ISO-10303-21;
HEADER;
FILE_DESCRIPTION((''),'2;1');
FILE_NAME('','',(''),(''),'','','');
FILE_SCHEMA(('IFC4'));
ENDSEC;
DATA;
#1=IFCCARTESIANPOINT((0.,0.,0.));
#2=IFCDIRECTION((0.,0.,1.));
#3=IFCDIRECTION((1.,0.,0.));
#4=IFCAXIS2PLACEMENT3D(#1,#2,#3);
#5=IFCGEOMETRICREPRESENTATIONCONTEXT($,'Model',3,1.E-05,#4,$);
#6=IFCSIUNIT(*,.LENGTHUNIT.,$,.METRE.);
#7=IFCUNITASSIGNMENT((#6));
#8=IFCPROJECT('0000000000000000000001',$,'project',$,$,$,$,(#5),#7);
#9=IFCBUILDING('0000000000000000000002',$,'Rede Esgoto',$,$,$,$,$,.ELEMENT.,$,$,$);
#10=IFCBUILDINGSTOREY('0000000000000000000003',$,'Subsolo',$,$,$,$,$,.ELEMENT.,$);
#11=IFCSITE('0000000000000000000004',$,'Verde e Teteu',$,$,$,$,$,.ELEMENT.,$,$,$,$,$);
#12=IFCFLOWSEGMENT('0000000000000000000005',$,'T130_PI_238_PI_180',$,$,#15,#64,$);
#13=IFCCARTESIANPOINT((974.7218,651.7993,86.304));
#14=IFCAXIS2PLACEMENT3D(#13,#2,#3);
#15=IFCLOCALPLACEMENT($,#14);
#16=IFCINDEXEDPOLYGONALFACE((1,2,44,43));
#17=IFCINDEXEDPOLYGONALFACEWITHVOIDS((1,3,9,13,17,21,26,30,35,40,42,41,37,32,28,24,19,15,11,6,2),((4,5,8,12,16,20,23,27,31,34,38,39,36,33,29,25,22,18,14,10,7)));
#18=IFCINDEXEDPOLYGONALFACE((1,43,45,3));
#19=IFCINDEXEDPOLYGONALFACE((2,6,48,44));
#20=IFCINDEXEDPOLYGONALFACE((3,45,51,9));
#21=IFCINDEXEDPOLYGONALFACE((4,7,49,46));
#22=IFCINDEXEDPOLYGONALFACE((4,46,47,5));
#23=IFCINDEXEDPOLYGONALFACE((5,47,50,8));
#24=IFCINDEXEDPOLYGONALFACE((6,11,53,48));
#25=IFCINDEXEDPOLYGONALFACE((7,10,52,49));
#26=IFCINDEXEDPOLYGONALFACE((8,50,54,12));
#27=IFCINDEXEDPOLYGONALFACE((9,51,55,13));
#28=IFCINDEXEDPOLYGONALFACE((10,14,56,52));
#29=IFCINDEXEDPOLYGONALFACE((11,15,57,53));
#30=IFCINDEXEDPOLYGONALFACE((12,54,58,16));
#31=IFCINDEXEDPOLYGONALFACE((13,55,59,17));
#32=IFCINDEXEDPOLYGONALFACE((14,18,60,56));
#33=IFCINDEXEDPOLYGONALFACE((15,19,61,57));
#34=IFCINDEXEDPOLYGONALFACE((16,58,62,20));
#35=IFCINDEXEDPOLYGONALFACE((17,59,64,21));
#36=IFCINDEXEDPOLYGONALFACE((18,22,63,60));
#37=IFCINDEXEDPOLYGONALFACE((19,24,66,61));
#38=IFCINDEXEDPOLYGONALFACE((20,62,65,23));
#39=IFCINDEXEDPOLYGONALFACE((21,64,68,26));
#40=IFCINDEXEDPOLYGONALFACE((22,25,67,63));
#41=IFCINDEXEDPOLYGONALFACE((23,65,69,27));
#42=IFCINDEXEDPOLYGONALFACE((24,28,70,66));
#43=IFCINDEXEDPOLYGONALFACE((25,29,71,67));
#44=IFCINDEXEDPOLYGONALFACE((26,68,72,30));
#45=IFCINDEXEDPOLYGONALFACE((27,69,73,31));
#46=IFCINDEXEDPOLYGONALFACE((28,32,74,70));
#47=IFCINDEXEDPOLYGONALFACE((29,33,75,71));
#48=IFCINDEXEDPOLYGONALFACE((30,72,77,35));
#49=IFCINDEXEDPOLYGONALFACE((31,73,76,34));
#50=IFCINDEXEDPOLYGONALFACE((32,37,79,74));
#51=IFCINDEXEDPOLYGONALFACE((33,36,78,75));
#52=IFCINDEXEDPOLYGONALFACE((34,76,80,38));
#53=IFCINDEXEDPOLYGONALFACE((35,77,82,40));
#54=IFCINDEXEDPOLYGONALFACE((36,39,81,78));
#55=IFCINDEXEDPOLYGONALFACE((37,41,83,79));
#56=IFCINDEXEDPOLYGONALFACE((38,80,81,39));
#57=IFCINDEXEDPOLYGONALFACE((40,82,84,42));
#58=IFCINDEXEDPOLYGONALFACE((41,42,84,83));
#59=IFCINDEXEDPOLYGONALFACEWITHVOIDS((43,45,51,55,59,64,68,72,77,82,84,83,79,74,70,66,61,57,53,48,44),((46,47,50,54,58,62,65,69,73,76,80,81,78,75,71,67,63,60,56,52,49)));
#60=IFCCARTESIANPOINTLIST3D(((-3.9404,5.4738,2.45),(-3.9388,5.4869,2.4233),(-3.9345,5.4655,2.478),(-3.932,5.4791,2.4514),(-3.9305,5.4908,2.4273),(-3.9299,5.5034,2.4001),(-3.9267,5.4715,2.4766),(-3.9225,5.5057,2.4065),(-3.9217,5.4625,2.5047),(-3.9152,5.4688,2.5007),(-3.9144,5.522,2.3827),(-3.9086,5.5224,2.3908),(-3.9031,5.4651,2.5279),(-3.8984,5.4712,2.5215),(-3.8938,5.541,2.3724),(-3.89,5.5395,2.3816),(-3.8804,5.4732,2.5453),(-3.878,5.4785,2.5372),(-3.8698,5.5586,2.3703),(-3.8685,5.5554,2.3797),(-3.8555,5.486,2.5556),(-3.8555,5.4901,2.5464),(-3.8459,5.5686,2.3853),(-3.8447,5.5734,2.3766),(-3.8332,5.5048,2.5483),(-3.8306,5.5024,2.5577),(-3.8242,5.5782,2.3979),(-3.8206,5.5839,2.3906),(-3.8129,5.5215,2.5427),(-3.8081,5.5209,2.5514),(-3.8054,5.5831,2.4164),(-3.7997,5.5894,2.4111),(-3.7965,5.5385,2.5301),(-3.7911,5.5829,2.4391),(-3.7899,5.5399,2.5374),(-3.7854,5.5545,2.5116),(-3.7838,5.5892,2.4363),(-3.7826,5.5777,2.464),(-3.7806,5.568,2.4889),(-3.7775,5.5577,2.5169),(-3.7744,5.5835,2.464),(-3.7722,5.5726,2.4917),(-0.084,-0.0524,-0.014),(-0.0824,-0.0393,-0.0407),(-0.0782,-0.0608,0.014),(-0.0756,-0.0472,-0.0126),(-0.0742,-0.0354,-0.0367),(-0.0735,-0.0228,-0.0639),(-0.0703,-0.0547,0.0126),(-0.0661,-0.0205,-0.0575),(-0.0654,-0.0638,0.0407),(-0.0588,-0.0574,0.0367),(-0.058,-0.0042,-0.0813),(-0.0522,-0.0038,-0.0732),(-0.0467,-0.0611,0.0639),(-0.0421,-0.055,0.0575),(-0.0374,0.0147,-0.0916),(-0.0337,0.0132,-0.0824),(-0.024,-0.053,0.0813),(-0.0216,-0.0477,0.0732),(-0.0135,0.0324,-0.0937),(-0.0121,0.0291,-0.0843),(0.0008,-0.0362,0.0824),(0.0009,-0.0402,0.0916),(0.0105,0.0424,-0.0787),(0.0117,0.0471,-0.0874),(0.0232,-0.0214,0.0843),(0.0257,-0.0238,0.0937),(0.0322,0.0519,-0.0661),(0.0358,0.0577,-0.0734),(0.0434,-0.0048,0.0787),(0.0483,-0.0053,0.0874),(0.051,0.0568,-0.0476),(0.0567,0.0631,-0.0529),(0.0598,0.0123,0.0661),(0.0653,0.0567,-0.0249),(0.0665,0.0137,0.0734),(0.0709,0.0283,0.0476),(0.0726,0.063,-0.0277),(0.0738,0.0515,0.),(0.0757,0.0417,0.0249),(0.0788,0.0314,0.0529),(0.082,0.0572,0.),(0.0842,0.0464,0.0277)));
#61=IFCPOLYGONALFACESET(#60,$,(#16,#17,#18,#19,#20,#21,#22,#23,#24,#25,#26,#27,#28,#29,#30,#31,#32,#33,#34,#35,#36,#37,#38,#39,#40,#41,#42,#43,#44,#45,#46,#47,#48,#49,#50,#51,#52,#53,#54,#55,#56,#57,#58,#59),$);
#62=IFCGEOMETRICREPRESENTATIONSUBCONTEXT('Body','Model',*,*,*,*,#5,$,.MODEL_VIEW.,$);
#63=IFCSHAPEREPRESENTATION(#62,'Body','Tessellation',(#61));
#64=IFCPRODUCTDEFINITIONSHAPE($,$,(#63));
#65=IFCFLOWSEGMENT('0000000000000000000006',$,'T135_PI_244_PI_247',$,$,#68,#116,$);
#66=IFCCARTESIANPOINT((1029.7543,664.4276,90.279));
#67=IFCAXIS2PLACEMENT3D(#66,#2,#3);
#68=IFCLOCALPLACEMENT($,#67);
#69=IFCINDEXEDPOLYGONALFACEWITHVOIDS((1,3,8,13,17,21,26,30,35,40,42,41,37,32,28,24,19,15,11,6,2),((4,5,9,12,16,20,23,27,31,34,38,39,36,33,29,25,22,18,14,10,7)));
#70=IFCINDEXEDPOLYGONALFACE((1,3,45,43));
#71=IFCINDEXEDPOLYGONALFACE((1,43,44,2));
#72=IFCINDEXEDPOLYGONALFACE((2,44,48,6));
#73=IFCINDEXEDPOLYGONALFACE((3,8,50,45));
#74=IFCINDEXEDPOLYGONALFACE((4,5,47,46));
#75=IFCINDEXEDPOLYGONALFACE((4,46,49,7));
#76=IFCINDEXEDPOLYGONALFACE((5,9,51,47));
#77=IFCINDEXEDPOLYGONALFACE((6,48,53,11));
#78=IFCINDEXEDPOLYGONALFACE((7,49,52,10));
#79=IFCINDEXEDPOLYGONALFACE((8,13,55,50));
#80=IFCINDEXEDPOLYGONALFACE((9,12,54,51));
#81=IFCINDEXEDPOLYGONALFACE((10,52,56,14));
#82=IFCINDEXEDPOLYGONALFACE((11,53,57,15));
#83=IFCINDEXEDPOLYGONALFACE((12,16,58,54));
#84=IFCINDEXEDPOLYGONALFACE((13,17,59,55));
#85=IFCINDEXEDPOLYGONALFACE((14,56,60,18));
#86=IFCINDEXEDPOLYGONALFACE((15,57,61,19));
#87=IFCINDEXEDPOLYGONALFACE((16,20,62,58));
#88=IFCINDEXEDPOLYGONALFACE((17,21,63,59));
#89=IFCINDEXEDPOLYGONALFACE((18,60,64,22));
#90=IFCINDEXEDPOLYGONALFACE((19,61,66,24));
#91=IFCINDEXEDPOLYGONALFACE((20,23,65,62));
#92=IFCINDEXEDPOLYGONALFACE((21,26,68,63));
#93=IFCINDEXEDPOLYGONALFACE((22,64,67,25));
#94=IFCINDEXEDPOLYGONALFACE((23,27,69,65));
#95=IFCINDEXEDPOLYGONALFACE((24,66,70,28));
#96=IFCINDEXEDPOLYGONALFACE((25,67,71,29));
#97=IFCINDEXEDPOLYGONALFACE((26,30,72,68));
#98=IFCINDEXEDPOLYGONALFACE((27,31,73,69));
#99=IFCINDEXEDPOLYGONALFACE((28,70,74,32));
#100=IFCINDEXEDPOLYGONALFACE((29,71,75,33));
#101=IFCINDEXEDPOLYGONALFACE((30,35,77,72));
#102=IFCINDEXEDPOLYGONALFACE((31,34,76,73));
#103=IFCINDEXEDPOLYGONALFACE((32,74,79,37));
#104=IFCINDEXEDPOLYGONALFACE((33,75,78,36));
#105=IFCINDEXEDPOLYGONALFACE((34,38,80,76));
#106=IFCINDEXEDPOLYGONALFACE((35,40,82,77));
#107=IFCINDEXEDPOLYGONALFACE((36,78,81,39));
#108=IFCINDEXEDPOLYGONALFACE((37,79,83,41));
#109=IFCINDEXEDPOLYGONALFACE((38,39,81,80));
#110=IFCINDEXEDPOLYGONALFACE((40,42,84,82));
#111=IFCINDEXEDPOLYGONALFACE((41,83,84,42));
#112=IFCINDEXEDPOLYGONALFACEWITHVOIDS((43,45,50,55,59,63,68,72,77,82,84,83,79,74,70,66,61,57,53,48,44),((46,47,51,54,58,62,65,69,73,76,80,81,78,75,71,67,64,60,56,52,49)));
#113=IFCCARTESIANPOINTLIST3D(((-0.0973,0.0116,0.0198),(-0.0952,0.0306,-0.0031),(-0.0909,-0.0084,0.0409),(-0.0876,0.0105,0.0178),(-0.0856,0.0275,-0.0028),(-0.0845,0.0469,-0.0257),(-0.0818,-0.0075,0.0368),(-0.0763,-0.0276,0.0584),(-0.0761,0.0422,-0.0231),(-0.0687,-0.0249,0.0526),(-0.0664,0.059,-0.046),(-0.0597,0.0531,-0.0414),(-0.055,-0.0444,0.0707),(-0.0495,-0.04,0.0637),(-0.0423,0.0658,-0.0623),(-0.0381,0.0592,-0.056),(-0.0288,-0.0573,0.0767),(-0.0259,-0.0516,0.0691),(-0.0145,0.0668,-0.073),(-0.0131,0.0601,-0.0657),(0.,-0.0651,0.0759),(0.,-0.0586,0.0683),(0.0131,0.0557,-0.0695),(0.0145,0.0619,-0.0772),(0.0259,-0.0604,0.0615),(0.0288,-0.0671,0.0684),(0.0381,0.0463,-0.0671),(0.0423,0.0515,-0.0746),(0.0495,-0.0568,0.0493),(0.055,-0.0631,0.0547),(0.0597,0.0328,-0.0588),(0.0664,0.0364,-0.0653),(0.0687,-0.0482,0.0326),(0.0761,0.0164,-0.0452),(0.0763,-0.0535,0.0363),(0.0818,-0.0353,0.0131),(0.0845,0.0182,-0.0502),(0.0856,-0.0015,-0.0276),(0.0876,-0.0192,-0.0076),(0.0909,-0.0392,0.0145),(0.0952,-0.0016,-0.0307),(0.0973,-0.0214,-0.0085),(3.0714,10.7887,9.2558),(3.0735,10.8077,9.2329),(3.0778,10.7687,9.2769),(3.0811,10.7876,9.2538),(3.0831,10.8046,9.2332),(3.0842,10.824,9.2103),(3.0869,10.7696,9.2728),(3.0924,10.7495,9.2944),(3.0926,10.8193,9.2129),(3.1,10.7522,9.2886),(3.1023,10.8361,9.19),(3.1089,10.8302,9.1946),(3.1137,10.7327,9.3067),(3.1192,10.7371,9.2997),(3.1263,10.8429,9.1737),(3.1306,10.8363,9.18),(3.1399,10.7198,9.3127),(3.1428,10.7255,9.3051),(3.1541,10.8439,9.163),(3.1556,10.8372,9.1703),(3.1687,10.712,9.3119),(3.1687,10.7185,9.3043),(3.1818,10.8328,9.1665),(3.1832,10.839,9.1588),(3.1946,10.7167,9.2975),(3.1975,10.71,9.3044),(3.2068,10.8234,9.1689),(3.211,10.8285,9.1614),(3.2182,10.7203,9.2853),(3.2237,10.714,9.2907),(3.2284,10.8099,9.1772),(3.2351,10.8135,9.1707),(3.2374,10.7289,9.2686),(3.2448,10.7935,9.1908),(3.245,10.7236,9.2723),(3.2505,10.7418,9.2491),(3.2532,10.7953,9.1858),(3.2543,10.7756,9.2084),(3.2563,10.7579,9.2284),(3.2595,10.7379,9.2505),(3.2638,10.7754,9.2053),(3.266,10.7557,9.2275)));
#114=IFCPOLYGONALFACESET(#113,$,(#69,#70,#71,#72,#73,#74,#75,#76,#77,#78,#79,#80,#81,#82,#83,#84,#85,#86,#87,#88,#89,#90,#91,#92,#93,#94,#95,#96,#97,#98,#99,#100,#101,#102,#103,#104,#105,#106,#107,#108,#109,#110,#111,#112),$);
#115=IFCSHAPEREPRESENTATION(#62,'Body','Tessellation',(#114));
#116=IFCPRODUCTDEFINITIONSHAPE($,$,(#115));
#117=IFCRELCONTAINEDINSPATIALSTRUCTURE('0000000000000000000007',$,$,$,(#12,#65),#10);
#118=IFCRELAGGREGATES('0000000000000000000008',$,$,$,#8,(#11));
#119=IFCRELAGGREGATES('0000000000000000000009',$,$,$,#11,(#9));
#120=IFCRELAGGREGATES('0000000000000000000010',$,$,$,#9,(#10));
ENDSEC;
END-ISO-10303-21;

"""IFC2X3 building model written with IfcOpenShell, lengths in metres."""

from ifc_helpers import new_model, entity, si_unit, frame, origin_with_axes, place, context, subcontext, project, spatial, element, save


model = new_model("IFC2X3")

# Units and contexts
model_context = context("Model", 3, precision=1e-05, world=origin_with_axes())
body_context = subcontext(model_context, "Body", "Model", "MODEL_VIEW")
ifc_project = project(units=[si_unit("LENGTHUNIT", "METRE")], contexts=[model_context])

# Site, building, storey
site = spatial("IfcSite", under=ifc_project, Name="Verde e Teteu", CompositionType="ELEMENT")
building = spatial("IfcBuilding", under=site, Name="Rede Esgoto", CompositionType="ELEMENT")
storey = spatial("IfcBuildingStorey", under=building, Name="Subsolo", CompositionType="ELEMENT")

# Flow segments
flow_segment_1_placement = place(None, frame((974.7218, 651.7993, 86.304), z_axis=(0.0, 0.0, 1.0), x_axis=(1.0, 0.0, 0.0)))
element("IfcFlowSegment", 1, at=flow_segment_1_placement, inside=storey, Name="T130_PI_238_PI_180", context=body_context, shape_type="SweptSolid", body=[
    entity("IfcSweptDiskSolid", entity("IfcPolyline", [entity("IfcCartesianPoint", [0.0, 0.0, 0.0]), entity("IfcCartesianPoint", [-3.8564, 5.5262, 2.464])]), 0.1, 0.09),
])
flow_segment_2_placement = place(None, frame((1029.7543, 664.4276, 90.279), z_axis=(0.0, 0.0, 1.0), x_axis=(1.0, 0.0, 0.0)))
element("IfcFlowSegment", 2, at=flow_segment_2_placement, inside=storey, Name="T135_PI_244_PI_247", context=body_context, shape_type="SweptSolid", body=[
    entity("IfcSweptDiskSolid", entity("IfcPolyline", [entity("IfcCartesianPoint", [0.0, 0.0, 0.0]), entity("IfcCartesianPoint", [3.1687, 10.7771, 9.236])]), 0.1, 0.09),
])

save(model, "model.ifc")
